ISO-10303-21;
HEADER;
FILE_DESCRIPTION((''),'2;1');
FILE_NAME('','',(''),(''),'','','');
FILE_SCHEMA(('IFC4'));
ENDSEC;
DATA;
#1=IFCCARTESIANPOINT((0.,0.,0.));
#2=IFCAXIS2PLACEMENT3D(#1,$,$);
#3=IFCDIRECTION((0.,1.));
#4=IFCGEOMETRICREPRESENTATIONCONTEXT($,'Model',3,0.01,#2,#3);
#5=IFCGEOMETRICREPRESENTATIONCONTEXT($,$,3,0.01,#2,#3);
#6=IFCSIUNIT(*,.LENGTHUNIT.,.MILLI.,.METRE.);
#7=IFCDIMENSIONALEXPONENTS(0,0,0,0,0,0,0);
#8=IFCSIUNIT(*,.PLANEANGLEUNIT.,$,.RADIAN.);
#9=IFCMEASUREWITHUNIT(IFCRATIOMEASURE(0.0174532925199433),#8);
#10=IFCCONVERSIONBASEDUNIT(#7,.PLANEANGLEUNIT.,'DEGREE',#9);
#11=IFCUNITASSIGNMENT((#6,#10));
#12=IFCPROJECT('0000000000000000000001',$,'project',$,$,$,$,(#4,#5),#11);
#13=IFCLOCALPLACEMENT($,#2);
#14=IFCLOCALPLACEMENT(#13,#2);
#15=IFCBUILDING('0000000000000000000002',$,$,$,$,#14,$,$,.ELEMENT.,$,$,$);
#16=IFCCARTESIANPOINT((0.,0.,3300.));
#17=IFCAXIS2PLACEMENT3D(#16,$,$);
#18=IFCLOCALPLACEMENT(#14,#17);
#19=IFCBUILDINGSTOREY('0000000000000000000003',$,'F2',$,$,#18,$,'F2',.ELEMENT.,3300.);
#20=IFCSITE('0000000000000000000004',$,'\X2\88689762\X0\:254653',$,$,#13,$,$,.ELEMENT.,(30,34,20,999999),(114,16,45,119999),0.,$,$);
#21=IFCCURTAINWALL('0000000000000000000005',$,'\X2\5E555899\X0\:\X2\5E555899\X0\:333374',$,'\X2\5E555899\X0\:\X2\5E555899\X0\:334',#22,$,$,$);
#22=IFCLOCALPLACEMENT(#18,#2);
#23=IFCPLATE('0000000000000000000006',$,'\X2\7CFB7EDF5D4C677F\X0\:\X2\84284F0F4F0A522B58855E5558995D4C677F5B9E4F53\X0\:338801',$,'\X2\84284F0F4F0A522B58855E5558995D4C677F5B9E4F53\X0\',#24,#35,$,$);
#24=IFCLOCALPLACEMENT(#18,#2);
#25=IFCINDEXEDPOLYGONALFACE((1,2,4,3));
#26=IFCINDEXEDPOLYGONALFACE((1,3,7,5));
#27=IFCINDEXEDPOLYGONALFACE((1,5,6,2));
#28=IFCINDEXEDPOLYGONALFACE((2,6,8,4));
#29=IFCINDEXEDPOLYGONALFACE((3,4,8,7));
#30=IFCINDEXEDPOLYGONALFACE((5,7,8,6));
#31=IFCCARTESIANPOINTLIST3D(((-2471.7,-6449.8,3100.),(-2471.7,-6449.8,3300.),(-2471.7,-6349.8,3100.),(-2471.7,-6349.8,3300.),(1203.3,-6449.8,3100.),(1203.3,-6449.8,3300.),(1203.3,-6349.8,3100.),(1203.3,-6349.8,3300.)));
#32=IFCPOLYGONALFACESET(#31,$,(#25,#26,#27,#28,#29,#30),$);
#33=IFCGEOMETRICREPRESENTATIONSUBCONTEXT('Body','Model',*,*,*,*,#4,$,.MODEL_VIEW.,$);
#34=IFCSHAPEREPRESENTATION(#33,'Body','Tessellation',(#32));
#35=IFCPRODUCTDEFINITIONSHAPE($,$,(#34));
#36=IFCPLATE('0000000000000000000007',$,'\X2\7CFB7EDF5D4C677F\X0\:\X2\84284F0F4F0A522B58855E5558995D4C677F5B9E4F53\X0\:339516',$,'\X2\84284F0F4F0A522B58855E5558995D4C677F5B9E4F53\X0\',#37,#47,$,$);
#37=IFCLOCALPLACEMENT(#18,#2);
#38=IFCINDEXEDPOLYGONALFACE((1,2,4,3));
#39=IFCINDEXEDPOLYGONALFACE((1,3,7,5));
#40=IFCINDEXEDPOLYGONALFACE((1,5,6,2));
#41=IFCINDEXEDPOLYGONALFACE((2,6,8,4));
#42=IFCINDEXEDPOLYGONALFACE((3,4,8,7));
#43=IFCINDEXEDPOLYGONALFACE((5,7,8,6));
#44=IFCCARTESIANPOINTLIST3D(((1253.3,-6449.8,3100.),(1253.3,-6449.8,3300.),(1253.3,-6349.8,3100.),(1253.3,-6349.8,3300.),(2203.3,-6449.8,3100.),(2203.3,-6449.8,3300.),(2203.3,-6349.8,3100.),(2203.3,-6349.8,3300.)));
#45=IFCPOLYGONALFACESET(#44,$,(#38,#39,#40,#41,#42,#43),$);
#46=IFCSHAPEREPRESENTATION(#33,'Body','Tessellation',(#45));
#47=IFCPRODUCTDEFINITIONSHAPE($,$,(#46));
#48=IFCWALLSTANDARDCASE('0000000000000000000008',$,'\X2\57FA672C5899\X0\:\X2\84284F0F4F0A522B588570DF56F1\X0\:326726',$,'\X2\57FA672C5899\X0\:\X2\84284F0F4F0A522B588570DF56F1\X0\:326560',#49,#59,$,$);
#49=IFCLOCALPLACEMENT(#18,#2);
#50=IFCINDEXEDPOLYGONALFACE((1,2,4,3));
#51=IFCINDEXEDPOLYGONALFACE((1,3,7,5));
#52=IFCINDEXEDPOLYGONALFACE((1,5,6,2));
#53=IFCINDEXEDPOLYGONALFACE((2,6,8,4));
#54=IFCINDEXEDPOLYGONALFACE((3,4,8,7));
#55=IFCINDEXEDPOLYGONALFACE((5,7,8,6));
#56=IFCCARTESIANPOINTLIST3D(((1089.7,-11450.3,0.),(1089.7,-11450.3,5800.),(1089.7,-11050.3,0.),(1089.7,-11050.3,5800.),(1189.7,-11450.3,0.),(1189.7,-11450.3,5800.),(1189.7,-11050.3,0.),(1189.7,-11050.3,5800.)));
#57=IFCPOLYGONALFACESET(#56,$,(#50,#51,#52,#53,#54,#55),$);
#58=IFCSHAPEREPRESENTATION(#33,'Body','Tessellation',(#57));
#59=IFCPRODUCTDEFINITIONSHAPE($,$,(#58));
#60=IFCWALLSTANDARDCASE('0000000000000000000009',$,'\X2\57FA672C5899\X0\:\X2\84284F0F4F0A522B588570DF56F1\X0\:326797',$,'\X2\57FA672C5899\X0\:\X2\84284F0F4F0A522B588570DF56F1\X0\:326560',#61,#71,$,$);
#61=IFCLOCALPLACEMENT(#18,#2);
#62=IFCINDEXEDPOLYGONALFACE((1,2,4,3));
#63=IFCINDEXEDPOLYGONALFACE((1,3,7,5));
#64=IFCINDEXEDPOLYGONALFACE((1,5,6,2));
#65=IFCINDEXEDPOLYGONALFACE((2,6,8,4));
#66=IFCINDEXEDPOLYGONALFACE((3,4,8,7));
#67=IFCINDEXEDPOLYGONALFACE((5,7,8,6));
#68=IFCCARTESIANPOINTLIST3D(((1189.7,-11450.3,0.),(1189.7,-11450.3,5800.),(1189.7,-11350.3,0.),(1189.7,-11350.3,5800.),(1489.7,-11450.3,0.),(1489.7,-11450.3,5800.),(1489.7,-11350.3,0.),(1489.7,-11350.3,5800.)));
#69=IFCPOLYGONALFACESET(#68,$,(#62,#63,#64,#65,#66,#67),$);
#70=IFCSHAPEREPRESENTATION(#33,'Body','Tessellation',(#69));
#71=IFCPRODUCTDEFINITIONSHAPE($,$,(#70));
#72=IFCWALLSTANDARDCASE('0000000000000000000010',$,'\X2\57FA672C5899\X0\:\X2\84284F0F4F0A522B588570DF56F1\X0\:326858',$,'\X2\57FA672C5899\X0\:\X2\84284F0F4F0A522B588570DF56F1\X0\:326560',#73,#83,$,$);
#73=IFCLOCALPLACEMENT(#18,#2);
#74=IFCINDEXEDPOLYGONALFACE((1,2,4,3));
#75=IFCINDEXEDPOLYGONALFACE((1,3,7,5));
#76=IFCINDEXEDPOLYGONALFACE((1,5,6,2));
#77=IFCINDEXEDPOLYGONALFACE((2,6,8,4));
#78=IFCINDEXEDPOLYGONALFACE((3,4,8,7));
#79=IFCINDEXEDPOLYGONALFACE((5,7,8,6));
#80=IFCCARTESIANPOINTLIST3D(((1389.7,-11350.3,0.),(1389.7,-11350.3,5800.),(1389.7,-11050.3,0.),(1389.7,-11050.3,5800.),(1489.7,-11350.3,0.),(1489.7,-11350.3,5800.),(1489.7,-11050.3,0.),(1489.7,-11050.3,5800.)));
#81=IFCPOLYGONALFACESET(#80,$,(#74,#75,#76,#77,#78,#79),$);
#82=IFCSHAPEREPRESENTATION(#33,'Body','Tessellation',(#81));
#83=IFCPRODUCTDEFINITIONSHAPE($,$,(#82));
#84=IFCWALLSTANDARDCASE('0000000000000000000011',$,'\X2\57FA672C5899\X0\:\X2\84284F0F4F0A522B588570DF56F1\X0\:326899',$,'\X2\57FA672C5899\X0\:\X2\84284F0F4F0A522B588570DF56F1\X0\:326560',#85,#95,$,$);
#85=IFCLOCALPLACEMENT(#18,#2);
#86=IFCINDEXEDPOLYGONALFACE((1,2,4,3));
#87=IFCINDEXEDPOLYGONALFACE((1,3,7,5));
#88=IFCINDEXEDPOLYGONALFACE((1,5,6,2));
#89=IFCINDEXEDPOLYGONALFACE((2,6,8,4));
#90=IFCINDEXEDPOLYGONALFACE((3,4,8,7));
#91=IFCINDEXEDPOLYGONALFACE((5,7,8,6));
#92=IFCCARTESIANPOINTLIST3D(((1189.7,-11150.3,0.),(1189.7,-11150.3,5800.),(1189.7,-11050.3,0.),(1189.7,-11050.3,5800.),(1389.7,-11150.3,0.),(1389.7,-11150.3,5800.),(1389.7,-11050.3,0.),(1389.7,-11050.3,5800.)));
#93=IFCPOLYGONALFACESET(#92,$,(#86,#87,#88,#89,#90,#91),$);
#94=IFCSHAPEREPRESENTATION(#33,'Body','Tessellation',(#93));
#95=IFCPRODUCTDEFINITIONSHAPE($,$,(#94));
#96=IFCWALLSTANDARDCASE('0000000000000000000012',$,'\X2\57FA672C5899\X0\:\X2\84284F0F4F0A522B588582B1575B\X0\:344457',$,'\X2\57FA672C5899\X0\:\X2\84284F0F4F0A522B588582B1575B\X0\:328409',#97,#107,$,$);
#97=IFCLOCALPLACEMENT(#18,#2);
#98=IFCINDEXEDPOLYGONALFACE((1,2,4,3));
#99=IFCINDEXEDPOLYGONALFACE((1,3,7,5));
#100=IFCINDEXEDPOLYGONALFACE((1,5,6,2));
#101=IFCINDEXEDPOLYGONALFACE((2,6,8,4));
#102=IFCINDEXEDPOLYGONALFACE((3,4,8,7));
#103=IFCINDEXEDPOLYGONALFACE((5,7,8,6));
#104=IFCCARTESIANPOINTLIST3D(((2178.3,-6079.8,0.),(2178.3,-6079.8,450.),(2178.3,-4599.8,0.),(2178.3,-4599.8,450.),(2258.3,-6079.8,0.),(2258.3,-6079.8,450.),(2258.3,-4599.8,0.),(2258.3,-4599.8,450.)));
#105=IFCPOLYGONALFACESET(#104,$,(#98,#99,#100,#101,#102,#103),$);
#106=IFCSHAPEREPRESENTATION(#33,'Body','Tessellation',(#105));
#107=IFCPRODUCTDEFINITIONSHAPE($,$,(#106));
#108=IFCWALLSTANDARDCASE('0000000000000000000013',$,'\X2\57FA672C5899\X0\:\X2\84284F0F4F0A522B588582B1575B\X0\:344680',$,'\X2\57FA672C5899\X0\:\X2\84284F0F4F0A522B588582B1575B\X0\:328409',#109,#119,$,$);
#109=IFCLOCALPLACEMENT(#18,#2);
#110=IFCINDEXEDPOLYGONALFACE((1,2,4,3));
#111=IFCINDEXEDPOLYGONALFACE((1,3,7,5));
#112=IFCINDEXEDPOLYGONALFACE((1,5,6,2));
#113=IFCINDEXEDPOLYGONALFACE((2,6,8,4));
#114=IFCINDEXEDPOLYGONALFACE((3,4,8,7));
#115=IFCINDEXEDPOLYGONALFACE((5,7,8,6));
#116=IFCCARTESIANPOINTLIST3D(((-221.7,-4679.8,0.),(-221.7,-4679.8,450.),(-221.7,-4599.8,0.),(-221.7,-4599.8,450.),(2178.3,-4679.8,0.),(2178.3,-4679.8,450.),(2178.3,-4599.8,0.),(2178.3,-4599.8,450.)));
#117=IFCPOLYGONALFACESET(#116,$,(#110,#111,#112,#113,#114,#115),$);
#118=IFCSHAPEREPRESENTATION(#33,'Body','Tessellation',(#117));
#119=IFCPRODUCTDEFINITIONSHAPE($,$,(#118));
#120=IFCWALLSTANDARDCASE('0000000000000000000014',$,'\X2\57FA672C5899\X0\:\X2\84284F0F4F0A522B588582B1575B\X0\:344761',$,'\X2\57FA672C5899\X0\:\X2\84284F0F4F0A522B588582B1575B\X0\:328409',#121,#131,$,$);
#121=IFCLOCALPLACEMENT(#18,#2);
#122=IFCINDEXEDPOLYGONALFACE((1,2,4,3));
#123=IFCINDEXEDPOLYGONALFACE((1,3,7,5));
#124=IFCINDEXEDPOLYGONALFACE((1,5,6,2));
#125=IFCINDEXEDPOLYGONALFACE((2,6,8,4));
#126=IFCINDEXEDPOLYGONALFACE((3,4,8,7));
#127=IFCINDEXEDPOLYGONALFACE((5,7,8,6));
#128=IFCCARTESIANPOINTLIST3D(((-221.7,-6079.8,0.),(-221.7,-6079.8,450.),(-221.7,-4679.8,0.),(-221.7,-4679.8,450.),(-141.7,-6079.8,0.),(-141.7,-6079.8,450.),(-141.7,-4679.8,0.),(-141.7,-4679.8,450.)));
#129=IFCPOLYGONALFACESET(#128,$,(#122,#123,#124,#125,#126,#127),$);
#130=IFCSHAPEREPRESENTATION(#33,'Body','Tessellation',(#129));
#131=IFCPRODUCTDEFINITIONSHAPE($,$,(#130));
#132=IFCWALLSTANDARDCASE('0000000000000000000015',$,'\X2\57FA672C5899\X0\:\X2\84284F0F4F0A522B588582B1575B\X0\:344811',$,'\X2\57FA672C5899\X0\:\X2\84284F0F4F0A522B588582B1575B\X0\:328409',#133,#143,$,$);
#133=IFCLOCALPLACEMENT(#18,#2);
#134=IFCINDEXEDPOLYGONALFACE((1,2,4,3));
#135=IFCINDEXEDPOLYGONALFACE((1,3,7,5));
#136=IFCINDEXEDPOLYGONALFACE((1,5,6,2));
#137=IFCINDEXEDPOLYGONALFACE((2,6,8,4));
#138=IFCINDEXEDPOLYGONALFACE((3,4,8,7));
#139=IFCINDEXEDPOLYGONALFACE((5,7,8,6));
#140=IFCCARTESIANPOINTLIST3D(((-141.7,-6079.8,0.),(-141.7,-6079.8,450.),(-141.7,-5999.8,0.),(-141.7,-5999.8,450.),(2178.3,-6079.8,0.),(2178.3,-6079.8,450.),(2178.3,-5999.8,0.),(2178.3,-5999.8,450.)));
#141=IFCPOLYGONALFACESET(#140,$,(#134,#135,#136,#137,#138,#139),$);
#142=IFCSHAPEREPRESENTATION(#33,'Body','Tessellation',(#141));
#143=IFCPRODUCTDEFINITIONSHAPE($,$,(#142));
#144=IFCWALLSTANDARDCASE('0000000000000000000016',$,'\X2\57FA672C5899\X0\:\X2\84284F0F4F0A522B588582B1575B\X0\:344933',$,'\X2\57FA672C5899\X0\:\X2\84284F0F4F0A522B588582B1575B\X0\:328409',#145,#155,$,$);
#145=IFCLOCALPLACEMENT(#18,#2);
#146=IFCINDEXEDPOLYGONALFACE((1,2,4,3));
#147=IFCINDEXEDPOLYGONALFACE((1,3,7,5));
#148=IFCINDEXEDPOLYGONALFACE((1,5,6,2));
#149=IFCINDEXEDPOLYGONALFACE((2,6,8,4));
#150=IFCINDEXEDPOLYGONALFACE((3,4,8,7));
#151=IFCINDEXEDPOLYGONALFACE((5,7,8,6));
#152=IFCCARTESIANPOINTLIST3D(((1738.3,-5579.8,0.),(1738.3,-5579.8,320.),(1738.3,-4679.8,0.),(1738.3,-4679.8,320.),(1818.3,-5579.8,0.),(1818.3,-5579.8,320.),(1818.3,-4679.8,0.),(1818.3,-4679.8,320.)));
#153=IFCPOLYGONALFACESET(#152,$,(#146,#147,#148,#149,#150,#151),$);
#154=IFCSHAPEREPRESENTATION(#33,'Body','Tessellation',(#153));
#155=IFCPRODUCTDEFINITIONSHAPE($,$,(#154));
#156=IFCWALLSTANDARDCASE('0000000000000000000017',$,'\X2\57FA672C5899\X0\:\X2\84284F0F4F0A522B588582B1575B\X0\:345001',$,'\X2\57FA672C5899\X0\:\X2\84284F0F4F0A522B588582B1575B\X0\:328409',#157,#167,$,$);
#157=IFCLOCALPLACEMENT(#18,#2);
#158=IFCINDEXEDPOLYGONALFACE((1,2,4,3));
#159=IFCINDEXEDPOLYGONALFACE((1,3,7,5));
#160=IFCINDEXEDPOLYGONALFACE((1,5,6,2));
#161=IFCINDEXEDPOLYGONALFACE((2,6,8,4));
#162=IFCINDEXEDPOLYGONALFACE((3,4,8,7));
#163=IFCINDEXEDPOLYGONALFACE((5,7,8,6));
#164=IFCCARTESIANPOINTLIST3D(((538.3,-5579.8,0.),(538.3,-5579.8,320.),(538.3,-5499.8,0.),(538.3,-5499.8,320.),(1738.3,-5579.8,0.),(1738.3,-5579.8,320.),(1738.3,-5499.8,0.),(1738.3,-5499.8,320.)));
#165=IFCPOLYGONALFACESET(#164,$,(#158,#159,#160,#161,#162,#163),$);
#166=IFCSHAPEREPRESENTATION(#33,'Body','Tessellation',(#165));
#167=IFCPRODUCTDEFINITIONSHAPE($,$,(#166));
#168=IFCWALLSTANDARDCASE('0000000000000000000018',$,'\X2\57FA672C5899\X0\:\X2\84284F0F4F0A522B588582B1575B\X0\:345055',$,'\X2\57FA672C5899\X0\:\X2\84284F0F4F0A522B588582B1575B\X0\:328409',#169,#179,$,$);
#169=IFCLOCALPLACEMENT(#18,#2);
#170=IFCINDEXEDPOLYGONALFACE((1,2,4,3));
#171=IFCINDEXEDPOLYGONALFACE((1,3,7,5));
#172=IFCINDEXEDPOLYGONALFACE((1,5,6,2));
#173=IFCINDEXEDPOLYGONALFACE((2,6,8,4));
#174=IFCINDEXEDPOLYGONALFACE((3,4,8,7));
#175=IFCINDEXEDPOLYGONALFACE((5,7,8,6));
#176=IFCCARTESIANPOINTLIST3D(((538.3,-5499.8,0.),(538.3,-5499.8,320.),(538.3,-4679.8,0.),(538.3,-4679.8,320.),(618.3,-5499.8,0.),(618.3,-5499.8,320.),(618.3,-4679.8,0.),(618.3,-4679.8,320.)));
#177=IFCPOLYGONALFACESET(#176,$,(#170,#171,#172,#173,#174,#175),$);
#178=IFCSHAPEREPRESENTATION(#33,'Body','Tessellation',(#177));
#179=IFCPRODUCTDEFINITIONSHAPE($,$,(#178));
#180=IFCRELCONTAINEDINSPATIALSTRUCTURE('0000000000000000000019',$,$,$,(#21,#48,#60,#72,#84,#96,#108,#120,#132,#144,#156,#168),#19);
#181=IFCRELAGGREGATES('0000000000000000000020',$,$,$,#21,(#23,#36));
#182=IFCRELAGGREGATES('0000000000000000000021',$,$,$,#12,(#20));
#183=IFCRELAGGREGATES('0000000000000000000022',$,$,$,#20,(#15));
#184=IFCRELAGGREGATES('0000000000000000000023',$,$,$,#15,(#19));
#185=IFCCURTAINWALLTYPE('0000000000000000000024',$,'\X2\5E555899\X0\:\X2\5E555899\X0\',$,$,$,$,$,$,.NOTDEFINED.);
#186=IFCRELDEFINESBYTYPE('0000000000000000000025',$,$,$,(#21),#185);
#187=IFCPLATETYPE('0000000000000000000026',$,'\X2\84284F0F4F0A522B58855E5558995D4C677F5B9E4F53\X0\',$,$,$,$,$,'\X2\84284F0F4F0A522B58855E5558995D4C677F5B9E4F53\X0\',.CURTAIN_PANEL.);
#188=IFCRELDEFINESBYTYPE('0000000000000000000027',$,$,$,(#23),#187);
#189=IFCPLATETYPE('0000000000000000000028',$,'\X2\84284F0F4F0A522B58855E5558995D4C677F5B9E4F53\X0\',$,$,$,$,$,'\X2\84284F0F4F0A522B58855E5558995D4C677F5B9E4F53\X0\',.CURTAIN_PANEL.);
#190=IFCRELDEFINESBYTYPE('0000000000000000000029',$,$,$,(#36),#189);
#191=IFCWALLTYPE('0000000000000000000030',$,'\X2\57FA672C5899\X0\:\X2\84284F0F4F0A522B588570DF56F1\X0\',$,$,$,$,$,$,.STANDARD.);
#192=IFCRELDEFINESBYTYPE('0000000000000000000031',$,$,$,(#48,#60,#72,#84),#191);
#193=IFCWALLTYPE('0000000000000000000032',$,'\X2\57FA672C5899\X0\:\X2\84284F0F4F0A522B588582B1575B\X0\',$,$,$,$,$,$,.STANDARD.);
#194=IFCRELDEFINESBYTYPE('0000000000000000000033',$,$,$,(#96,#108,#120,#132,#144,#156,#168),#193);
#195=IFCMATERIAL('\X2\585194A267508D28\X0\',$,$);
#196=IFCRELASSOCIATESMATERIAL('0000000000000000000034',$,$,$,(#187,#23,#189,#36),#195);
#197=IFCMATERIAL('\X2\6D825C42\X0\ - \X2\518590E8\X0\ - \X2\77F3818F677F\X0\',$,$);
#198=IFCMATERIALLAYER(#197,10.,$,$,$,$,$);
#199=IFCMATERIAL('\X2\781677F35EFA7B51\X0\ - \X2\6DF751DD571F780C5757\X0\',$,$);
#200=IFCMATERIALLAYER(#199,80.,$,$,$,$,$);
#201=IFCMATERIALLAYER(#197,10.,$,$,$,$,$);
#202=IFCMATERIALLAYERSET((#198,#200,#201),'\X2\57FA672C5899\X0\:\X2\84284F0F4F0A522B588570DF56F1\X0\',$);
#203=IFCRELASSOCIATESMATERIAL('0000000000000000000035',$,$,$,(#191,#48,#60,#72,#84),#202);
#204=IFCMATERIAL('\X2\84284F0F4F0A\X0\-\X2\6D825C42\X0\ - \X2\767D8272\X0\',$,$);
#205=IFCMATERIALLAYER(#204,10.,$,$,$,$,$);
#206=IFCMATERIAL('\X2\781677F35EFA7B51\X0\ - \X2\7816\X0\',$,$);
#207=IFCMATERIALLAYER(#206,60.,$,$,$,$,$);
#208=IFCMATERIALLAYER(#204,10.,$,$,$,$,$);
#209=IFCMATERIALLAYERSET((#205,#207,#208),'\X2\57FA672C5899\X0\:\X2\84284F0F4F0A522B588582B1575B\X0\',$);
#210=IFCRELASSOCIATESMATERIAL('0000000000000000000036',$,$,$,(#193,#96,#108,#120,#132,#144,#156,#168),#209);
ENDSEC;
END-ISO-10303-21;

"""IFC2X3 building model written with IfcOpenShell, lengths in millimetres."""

from ifc_helpers import new_model, entity, si_unit, converted_unit, direction, frame, frame_2d, origin, origin_2d_with_axis, place, context, subcontext, project, spatial, rectangle, extrude, source, transform, mapped, material, layer, layer_set, layer_usage, type_object, type_shapes, element, aggregate, save


model = new_model("IFC2X3")

# Units and contexts
model_context = context("Model", 3, precision=0.01, world=origin(), true_north=direction((0.0, 1.0)))
context_of_model = context(None, 3, precision=0.01, world=origin(), true_north=direction((0.0, 1.0)))
body_context = subcontext(model_context, "Body", "Model", "MODEL_VIEW")
ifc_project = project(units=[si_unit("LENGTHUNIT", "METRE", prefix="MILLI"), converted_unit("PLANEANGLEUNIT", "DEGREE", entity("IfcRatioMeasure", 0.0174532925199433), si_unit("PLANEANGLEUNIT", "RADIAN"), dimensions=[0, 0, 0, 0, 0, 0, 0])], contexts=[model_context, context_of_model])

# Site, building, storey
site_placement = place(None, origin())
site = spatial("IfcSite", under=ifc_project, at=site_placement, Name="表面:254653", CompositionType="ELEMENT", RefLatitude=(30, 34, 20, 999999), RefLongitude=(114, 16, 45, 119999), RefElevation=0.0)
building_placement = place(site_placement, origin())
building = spatial("IfcBuilding", under=site, at=building_placement, CompositionType="ELEMENT")
storey_placement = place(building_placement, frame((0.0, 0.0, 3300.0)))
storey = spatial("IfcBuildingStorey", under=building, at=storey_placement, Name="F2", LongName="F2", CompositionType="ELEMENT", Elevation=3300.0)

# Curtain wall, plates
curtain_wall_type_1 = type_object("IfcCurtainWallType", Name="幕墙:幕墙", PredefinedType="NOTDEFINED")
curtain_wall_1_placement = place(storey_placement, frame((0.0, 0.0, -3300.0)))
curtain_wall_1 = element("IfcCurtainWall", 1, at=curtain_wall_1_placement, inside=storey, type_object=curtain_wall_type_1, Name="幕墙:幕墙:333374", ObjectType="幕墙:幕墙:334")
ifc_material_1 = material(Name="塑钢材质")
plate_type_1 = type_object("IfcPlateType", Name="萨伏伊别墅幕墙嵌板实体", ElementType="萨伏伊别墅幕墙嵌板实体", PredefinedType="CURTAIN_PANEL", material=ifc_material_1)
shared_shape_1 = source(origin(), body_context, "Body", "SweptSolid", [
    extrude(rectangle(XDim=100.0, YDim=3675.0, at=origin_2d_with_axis()), frame((0.0, 0.0, 0.0), z_axis=(0.0, 0.0, 1.0), x_axis=(0.0, 1.0, 0.0)), (0.0, 0.0, 1.0), 200.0),
])
type_shapes(plate_type_1, [shared_shape_1])
plate_1_placement = place(curtain_wall_1_placement, frame((-634.2, -6399.8, 6400.0)))
plate_1 = element("IfcPlate", 2, at=plate_1_placement, type_object=plate_type_1, material=ifc_material_1, Name="系统嵌板:萨伏伊别墅幕墙嵌板实体:338801", ObjectType="萨伏伊别墅幕墙嵌板实体", context=body_context, shape_type="MappedRepresentation", body=[
    mapped(shared_shape_1, transform((0.0, 0.0, 0.0), scale=1.0)),
])
plate_type_2 = type_object("IfcPlateType", Name="萨伏伊别墅幕墙嵌板实体", ElementType="萨伏伊别墅幕墙嵌板实体", PredefinedType="CURTAIN_PANEL", material=ifc_material_1)
shared_shape_2 = source(origin(), body_context, "Body", "SweptSolid", [
    extrude(rectangle(XDim=100.0, YDim=950.0, at=origin_2d_with_axis()), frame((0.0, 0.0, 0.0), z_axis=(0.0, 0.0, 1.0), x_axis=(0.0, 1.0, 0.0)), (0.0, 0.0, 1.0), 200.0),
])
type_shapes(plate_type_2, [shared_shape_2])
plate_2_placement = place(curtain_wall_1_placement, frame((1728.3, -6399.8, 6400.0)))
plate_2 = element("IfcPlate", 3, at=plate_2_placement, type_object=plate_type_2, material=ifc_material_1, Name="系统嵌板:萨伏伊别墅幕墙嵌板实体:339516", ObjectType="萨伏伊别墅幕墙嵌板实体", context=body_context, shape_type="MappedRepresentation", body=[
    mapped(shared_shape_2, transform((0.0, 0.0, 0.0), scale=1.0)),
])
aggregate(curtain_wall_1, [plate_1, plate_2])

# Shared definitions
ifc_material_2 = material(Name="萨伏伊-涂层 - 白色")
ifc_material_3 = material(Name="砖石建筑 - 砖")

# Walls
ifc_material_4 = material(Name="涂层 - 内部 - 石膏板")
ifc_layer_1 = layer(ifc_material_4, 10.0)
ifc_material_5 = material(Name="砖石建筑 - 混凝土砌块")
ifc_layer_2 = layer(ifc_material_5, 80.0)
ifc_layer_3 = layer(ifc_material_4, 10.0)
ifc_layer_set_1 = layer_set([ifc_layer_1, ifc_layer_2, ifc_layer_3], Name="基本墙:萨伏伊别墅烟囱")
ifc_layer_usage_1 = layer_usage(ifc_layer_set_1, "AXIS2", "NEGATIVE", 50.0)
wall_type_1 = type_object("IfcWallType", Name="基本墙:萨伏伊别墅烟囱", PredefinedType="STANDARD", material=ifc_layer_set_1)
wall_1_placement = place(storey_placement, frame((1139.7, -11050.3, 0.0), z_axis=(0.0, 0.0, 1.0), x_axis=(0.0, -1.0, 0.0)))
element("IfcWallStandardCase", 4, at=wall_1_placement, inside=storey, type_object=wall_type_1, material=ifc_layer_usage_1, Name="基本墙:萨伏伊别墅烟囱:326726", ObjectType="基本墙:萨伏伊别墅烟囱:326560", context=body_context, shape_type="SweptSolid", body=[
    extrude(rectangle(XDim=400.0, YDim=100.0, at=frame_2d((200.0, 0.0), x_axis=(-1.0, 0.0))), origin(), (0.0, 0.0, 1.0), 5800.0),
])
ifc_layer_usage_2 = layer_usage(ifc_layer_set_1, "AXIS2", "NEGATIVE", 50.0)
wall_2_placement = place(storey_placement, frame((1189.7, -11400.3, 0.0)))
element("IfcWallStandardCase", 5, at=wall_2_placement, inside=storey, type_object=wall_type_1, material=ifc_layer_usage_2, Name="基本墙:萨伏伊别墅烟囱:326797", ObjectType="基本墙:萨伏伊别墅烟囱:326560", context=body_context, shape_type="SweptSolid", body=[
    extrude(rectangle(XDim=300.0, YDim=100.0, at=frame_2d((150.0, 0.0), x_axis=(-1.0, 0.0))), origin(), (0.0, 0.0, 1.0), 5800.0),
])
ifc_layer_usage_3 = layer_usage(ifc_layer_set_1, "AXIS2", "NEGATIVE", 50.0)
wall_3_placement = place(storey_placement, frame((1439.7, -11350.3, 0.0), z_axis=(0.0, 0.0, 1.0), x_axis=(0.0, 1.0, 0.0)))
element("IfcWallStandardCase", 6, at=wall_3_placement, inside=storey, type_object=wall_type_1, material=ifc_layer_usage_3, Name="基本墙:萨伏伊别墅烟囱:326858", ObjectType="基本墙:萨伏伊别墅烟囱:326560", context=body_context, shape_type="SweptSolid", body=[
    extrude(rectangle(XDim=300.0, YDim=100.0, at=frame_2d((150.0, 0.0), x_axis=(-1.0, 0.0))), origin(), (0.0, 0.0, 1.0), 5800.0),
])
ifc_layer_usage_4 = layer_usage(ifc_layer_set_1, "AXIS2", "NEGATIVE", 50.0)
wall_4_placement = place(storey_placement, frame((1389.7, -11100.3, 0.0), z_axis=(0.0, 0.0, 1.0), x_axis=(-1.0, 0.0, 0.0)))
element("IfcWallStandardCase", 7, at=wall_4_placement, inside=storey, type_object=wall_type_1, material=ifc_layer_usage_4, Name="基本墙:萨伏伊别墅烟囱:326899", ObjectType="基本墙:萨伏伊别墅烟囱:326560", context=body_context, shape_type="SweptSolid", body=[
    extrude(rectangle(XDim=200.0, YDim=100.0, at=frame_2d((100.0, 0.0), x_axis=(-1.0, 0.0))), origin(), (0.0, 0.0, 1.0), 5800.0),
])
ifc_layer_4 = layer(ifc_material_2, 10.0)
ifc_layer_5 = layer(ifc_material_3, 60.0)
ifc_layer_6 = layer(ifc_material_2, 10.0)
ifc_layer_set_2 = layer_set([ifc_layer_4, ifc_layer_5, ifc_layer_6], Name="基本墙:萨伏伊别墅花坛")
ifc_layer_usage_5 = layer_usage(ifc_layer_set_2, "AXIS2", "NEGATIVE", 40.0)
wall_type_2 = type_object("IfcWallType", Name="基本墙:萨伏伊别墅花坛", PredefinedType="STANDARD", material=ifc_layer_set_2)
wall_5_placement = place(storey_placement, frame((2218.3, -6079.8, 0.0), z_axis=(0.0, 0.0, 1.0), x_axis=(0.0, 1.0, 0.0)))
element("IfcWallStandardCase", 8, at=wall_5_placement, inside=storey, type_object=wall_type_2, material=ifc_layer_usage_5, Name="基本墙:萨伏伊别墅花坛:344457", ObjectType="基本墙:萨伏伊别墅花坛:328409", context=body_context, shape_type="SweptSolid", body=[
    extrude(rectangle(XDim=1480.0, YDim=80.0, at=frame_2d((740.0, 0.0), x_axis=(-1.0, 0.0))), origin(), (0.0, 0.0, 1.0), 450.0),
])
ifc_layer_usage_6 = layer_usage(ifc_layer_set_2, "AXIS2", "NEGATIVE", 40.0)
wall_6_placement = place(storey_placement, frame((2178.3, -4639.8, 0.0), z_axis=(0.0, 0.0, 1.0), x_axis=(-1.0, 0.0, 0.0)))
element("IfcWallStandardCase", 9, at=wall_6_placement, inside=storey, type_object=wall_type_2, material=ifc_layer_usage_6, Name="基本墙:萨伏伊别墅花坛:344680", ObjectType="基本墙:萨伏伊别墅花坛:328409", context=body_context, shape_type="SweptSolid", body=[
    extrude(rectangle(XDim=2400.0, YDim=80.0, at=frame_2d((1200.0, 0.0), x_axis=(-1.0, 0.0))), origin(), (0.0, 0.0, 1.0), 450.0),
])
ifc_layer_usage_7 = layer_usage(ifc_layer_set_2, "AXIS2", "NEGATIVE", 40.0)
wall_7_placement = place(storey_placement, frame((-181.7, -4679.8, 0.0), z_axis=(0.0, 0.0, 1.0), x_axis=(0.0, -1.0, 0.0)))
element("IfcWallStandardCase", 10, at=wall_7_placement, inside=storey, type_object=wall_type_2, material=ifc_layer_usage_7, Name="基本墙:萨伏伊别墅花坛:344761", ObjectType="基本墙:萨伏伊别墅花坛:328409", context=body_context, shape_type="SweptSolid", body=[
    extrude(rectangle(XDim=1400.0, YDim=80.0, at=frame_2d((700.0, 0.0), x_axis=(-1.0, 0.0))), origin(), (0.0, 0.0, 1.0), 450.0),
])
ifc_layer_usage_8 = layer_usage(ifc_layer_set_2, "AXIS2", "NEGATIVE", 40.0)
wall_8_placement = place(storey_placement, frame((-141.7, -6039.8, 0.0)))
element("IfcWallStandardCase", 11, at=wall_8_placement, inside=storey, type_object=wall_type_2, material=ifc_layer_usage_8, Name="基本墙:萨伏伊别墅花坛:344811", ObjectType="基本墙:萨伏伊别墅花坛:328409", context=body_context, shape_type="SweptSolid", body=[
    extrude(rectangle(XDim=2320.0, YDim=80.0, at=frame_2d((1160.0, 0.0), x_axis=(-1.0, 0.0))), origin(), (0.0, 0.0, 1.0), 450.0),
])
ifc_layer_usage_9 = layer_usage(ifc_layer_set_2, "AXIS2", "NEGATIVE", 40.0)
wall_9_placement = place(storey_placement, frame((1778.3, -4679.8, 0.0), z_axis=(0.0, 0.0, 1.0), x_axis=(0.0, -1.0, 0.0)))
element("IfcWallStandardCase", 12, at=wall_9_placement, inside=storey, type_object=wall_type_2, material=ifc_layer_usage_9, Name="基本墙:萨伏伊别墅花坛:344933", ObjectType="基本墙:萨伏伊别墅花坛:328409", context=body_context, shape_type="SweptSolid", body=[
    extrude(rectangle(XDim=900.0, YDim=80.0, at=frame_2d((450.0, 0.0), x_axis=(-1.0, 0.0))), origin(), (0.0, 0.0, 1.0), 320.0),
])
ifc_layer_usage_10 = layer_usage(ifc_layer_set_2, "AXIS2", "NEGATIVE", 40.0)
wall_10_placement = place(storey_placement, frame((1738.3, -5539.8, 0.0), z_axis=(0.0, 0.0, 1.0), x_axis=(-1.0, 0.0, 0.0)))
element("IfcWallStandardCase", 13, at=wall_10_placement, inside=storey, type_object=wall_type_2, material=ifc_layer_usage_10, Name="基本墙:萨伏伊别墅花坛:345001", ObjectType="基本墙:萨伏伊别墅花坛:328409", context=body_context, shape_type="SweptSolid", body=[
    extrude(rectangle(XDim=1200.0, YDim=80.0, at=frame_2d((600.0, 0.0), x_axis=(-1.0, 0.0))), origin(), (0.0, 0.0, 1.0), 320.0),
])
ifc_layer_usage_11 = layer_usage(ifc_layer_set_2, "AXIS2", "NEGATIVE", 40.0)
wall_11_placement = place(storey_placement, frame((578.3, -5499.8, 0.0), z_axis=(0.0, 0.0, 1.0), x_axis=(0.0, 1.0, 0.0)))
element("IfcWallStandardCase", 14, at=wall_11_placement, inside=storey, type_object=wall_type_2, material=ifc_layer_usage_11, Name="基本墙:萨伏伊别墅花坛:345055", ObjectType="基本墙:萨伏伊别墅花坛:328409", context=body_context, shape_type="SweptSolid", body=[
    extrude(rectangle(XDim=820.0, YDim=80.0, at=frame_2d((410.0, 0.0), x_axis=(-1.0, 0.0))), origin(), (0.0, 0.0, 1.0), 320.0),
])

save(model, "model.ifc")
